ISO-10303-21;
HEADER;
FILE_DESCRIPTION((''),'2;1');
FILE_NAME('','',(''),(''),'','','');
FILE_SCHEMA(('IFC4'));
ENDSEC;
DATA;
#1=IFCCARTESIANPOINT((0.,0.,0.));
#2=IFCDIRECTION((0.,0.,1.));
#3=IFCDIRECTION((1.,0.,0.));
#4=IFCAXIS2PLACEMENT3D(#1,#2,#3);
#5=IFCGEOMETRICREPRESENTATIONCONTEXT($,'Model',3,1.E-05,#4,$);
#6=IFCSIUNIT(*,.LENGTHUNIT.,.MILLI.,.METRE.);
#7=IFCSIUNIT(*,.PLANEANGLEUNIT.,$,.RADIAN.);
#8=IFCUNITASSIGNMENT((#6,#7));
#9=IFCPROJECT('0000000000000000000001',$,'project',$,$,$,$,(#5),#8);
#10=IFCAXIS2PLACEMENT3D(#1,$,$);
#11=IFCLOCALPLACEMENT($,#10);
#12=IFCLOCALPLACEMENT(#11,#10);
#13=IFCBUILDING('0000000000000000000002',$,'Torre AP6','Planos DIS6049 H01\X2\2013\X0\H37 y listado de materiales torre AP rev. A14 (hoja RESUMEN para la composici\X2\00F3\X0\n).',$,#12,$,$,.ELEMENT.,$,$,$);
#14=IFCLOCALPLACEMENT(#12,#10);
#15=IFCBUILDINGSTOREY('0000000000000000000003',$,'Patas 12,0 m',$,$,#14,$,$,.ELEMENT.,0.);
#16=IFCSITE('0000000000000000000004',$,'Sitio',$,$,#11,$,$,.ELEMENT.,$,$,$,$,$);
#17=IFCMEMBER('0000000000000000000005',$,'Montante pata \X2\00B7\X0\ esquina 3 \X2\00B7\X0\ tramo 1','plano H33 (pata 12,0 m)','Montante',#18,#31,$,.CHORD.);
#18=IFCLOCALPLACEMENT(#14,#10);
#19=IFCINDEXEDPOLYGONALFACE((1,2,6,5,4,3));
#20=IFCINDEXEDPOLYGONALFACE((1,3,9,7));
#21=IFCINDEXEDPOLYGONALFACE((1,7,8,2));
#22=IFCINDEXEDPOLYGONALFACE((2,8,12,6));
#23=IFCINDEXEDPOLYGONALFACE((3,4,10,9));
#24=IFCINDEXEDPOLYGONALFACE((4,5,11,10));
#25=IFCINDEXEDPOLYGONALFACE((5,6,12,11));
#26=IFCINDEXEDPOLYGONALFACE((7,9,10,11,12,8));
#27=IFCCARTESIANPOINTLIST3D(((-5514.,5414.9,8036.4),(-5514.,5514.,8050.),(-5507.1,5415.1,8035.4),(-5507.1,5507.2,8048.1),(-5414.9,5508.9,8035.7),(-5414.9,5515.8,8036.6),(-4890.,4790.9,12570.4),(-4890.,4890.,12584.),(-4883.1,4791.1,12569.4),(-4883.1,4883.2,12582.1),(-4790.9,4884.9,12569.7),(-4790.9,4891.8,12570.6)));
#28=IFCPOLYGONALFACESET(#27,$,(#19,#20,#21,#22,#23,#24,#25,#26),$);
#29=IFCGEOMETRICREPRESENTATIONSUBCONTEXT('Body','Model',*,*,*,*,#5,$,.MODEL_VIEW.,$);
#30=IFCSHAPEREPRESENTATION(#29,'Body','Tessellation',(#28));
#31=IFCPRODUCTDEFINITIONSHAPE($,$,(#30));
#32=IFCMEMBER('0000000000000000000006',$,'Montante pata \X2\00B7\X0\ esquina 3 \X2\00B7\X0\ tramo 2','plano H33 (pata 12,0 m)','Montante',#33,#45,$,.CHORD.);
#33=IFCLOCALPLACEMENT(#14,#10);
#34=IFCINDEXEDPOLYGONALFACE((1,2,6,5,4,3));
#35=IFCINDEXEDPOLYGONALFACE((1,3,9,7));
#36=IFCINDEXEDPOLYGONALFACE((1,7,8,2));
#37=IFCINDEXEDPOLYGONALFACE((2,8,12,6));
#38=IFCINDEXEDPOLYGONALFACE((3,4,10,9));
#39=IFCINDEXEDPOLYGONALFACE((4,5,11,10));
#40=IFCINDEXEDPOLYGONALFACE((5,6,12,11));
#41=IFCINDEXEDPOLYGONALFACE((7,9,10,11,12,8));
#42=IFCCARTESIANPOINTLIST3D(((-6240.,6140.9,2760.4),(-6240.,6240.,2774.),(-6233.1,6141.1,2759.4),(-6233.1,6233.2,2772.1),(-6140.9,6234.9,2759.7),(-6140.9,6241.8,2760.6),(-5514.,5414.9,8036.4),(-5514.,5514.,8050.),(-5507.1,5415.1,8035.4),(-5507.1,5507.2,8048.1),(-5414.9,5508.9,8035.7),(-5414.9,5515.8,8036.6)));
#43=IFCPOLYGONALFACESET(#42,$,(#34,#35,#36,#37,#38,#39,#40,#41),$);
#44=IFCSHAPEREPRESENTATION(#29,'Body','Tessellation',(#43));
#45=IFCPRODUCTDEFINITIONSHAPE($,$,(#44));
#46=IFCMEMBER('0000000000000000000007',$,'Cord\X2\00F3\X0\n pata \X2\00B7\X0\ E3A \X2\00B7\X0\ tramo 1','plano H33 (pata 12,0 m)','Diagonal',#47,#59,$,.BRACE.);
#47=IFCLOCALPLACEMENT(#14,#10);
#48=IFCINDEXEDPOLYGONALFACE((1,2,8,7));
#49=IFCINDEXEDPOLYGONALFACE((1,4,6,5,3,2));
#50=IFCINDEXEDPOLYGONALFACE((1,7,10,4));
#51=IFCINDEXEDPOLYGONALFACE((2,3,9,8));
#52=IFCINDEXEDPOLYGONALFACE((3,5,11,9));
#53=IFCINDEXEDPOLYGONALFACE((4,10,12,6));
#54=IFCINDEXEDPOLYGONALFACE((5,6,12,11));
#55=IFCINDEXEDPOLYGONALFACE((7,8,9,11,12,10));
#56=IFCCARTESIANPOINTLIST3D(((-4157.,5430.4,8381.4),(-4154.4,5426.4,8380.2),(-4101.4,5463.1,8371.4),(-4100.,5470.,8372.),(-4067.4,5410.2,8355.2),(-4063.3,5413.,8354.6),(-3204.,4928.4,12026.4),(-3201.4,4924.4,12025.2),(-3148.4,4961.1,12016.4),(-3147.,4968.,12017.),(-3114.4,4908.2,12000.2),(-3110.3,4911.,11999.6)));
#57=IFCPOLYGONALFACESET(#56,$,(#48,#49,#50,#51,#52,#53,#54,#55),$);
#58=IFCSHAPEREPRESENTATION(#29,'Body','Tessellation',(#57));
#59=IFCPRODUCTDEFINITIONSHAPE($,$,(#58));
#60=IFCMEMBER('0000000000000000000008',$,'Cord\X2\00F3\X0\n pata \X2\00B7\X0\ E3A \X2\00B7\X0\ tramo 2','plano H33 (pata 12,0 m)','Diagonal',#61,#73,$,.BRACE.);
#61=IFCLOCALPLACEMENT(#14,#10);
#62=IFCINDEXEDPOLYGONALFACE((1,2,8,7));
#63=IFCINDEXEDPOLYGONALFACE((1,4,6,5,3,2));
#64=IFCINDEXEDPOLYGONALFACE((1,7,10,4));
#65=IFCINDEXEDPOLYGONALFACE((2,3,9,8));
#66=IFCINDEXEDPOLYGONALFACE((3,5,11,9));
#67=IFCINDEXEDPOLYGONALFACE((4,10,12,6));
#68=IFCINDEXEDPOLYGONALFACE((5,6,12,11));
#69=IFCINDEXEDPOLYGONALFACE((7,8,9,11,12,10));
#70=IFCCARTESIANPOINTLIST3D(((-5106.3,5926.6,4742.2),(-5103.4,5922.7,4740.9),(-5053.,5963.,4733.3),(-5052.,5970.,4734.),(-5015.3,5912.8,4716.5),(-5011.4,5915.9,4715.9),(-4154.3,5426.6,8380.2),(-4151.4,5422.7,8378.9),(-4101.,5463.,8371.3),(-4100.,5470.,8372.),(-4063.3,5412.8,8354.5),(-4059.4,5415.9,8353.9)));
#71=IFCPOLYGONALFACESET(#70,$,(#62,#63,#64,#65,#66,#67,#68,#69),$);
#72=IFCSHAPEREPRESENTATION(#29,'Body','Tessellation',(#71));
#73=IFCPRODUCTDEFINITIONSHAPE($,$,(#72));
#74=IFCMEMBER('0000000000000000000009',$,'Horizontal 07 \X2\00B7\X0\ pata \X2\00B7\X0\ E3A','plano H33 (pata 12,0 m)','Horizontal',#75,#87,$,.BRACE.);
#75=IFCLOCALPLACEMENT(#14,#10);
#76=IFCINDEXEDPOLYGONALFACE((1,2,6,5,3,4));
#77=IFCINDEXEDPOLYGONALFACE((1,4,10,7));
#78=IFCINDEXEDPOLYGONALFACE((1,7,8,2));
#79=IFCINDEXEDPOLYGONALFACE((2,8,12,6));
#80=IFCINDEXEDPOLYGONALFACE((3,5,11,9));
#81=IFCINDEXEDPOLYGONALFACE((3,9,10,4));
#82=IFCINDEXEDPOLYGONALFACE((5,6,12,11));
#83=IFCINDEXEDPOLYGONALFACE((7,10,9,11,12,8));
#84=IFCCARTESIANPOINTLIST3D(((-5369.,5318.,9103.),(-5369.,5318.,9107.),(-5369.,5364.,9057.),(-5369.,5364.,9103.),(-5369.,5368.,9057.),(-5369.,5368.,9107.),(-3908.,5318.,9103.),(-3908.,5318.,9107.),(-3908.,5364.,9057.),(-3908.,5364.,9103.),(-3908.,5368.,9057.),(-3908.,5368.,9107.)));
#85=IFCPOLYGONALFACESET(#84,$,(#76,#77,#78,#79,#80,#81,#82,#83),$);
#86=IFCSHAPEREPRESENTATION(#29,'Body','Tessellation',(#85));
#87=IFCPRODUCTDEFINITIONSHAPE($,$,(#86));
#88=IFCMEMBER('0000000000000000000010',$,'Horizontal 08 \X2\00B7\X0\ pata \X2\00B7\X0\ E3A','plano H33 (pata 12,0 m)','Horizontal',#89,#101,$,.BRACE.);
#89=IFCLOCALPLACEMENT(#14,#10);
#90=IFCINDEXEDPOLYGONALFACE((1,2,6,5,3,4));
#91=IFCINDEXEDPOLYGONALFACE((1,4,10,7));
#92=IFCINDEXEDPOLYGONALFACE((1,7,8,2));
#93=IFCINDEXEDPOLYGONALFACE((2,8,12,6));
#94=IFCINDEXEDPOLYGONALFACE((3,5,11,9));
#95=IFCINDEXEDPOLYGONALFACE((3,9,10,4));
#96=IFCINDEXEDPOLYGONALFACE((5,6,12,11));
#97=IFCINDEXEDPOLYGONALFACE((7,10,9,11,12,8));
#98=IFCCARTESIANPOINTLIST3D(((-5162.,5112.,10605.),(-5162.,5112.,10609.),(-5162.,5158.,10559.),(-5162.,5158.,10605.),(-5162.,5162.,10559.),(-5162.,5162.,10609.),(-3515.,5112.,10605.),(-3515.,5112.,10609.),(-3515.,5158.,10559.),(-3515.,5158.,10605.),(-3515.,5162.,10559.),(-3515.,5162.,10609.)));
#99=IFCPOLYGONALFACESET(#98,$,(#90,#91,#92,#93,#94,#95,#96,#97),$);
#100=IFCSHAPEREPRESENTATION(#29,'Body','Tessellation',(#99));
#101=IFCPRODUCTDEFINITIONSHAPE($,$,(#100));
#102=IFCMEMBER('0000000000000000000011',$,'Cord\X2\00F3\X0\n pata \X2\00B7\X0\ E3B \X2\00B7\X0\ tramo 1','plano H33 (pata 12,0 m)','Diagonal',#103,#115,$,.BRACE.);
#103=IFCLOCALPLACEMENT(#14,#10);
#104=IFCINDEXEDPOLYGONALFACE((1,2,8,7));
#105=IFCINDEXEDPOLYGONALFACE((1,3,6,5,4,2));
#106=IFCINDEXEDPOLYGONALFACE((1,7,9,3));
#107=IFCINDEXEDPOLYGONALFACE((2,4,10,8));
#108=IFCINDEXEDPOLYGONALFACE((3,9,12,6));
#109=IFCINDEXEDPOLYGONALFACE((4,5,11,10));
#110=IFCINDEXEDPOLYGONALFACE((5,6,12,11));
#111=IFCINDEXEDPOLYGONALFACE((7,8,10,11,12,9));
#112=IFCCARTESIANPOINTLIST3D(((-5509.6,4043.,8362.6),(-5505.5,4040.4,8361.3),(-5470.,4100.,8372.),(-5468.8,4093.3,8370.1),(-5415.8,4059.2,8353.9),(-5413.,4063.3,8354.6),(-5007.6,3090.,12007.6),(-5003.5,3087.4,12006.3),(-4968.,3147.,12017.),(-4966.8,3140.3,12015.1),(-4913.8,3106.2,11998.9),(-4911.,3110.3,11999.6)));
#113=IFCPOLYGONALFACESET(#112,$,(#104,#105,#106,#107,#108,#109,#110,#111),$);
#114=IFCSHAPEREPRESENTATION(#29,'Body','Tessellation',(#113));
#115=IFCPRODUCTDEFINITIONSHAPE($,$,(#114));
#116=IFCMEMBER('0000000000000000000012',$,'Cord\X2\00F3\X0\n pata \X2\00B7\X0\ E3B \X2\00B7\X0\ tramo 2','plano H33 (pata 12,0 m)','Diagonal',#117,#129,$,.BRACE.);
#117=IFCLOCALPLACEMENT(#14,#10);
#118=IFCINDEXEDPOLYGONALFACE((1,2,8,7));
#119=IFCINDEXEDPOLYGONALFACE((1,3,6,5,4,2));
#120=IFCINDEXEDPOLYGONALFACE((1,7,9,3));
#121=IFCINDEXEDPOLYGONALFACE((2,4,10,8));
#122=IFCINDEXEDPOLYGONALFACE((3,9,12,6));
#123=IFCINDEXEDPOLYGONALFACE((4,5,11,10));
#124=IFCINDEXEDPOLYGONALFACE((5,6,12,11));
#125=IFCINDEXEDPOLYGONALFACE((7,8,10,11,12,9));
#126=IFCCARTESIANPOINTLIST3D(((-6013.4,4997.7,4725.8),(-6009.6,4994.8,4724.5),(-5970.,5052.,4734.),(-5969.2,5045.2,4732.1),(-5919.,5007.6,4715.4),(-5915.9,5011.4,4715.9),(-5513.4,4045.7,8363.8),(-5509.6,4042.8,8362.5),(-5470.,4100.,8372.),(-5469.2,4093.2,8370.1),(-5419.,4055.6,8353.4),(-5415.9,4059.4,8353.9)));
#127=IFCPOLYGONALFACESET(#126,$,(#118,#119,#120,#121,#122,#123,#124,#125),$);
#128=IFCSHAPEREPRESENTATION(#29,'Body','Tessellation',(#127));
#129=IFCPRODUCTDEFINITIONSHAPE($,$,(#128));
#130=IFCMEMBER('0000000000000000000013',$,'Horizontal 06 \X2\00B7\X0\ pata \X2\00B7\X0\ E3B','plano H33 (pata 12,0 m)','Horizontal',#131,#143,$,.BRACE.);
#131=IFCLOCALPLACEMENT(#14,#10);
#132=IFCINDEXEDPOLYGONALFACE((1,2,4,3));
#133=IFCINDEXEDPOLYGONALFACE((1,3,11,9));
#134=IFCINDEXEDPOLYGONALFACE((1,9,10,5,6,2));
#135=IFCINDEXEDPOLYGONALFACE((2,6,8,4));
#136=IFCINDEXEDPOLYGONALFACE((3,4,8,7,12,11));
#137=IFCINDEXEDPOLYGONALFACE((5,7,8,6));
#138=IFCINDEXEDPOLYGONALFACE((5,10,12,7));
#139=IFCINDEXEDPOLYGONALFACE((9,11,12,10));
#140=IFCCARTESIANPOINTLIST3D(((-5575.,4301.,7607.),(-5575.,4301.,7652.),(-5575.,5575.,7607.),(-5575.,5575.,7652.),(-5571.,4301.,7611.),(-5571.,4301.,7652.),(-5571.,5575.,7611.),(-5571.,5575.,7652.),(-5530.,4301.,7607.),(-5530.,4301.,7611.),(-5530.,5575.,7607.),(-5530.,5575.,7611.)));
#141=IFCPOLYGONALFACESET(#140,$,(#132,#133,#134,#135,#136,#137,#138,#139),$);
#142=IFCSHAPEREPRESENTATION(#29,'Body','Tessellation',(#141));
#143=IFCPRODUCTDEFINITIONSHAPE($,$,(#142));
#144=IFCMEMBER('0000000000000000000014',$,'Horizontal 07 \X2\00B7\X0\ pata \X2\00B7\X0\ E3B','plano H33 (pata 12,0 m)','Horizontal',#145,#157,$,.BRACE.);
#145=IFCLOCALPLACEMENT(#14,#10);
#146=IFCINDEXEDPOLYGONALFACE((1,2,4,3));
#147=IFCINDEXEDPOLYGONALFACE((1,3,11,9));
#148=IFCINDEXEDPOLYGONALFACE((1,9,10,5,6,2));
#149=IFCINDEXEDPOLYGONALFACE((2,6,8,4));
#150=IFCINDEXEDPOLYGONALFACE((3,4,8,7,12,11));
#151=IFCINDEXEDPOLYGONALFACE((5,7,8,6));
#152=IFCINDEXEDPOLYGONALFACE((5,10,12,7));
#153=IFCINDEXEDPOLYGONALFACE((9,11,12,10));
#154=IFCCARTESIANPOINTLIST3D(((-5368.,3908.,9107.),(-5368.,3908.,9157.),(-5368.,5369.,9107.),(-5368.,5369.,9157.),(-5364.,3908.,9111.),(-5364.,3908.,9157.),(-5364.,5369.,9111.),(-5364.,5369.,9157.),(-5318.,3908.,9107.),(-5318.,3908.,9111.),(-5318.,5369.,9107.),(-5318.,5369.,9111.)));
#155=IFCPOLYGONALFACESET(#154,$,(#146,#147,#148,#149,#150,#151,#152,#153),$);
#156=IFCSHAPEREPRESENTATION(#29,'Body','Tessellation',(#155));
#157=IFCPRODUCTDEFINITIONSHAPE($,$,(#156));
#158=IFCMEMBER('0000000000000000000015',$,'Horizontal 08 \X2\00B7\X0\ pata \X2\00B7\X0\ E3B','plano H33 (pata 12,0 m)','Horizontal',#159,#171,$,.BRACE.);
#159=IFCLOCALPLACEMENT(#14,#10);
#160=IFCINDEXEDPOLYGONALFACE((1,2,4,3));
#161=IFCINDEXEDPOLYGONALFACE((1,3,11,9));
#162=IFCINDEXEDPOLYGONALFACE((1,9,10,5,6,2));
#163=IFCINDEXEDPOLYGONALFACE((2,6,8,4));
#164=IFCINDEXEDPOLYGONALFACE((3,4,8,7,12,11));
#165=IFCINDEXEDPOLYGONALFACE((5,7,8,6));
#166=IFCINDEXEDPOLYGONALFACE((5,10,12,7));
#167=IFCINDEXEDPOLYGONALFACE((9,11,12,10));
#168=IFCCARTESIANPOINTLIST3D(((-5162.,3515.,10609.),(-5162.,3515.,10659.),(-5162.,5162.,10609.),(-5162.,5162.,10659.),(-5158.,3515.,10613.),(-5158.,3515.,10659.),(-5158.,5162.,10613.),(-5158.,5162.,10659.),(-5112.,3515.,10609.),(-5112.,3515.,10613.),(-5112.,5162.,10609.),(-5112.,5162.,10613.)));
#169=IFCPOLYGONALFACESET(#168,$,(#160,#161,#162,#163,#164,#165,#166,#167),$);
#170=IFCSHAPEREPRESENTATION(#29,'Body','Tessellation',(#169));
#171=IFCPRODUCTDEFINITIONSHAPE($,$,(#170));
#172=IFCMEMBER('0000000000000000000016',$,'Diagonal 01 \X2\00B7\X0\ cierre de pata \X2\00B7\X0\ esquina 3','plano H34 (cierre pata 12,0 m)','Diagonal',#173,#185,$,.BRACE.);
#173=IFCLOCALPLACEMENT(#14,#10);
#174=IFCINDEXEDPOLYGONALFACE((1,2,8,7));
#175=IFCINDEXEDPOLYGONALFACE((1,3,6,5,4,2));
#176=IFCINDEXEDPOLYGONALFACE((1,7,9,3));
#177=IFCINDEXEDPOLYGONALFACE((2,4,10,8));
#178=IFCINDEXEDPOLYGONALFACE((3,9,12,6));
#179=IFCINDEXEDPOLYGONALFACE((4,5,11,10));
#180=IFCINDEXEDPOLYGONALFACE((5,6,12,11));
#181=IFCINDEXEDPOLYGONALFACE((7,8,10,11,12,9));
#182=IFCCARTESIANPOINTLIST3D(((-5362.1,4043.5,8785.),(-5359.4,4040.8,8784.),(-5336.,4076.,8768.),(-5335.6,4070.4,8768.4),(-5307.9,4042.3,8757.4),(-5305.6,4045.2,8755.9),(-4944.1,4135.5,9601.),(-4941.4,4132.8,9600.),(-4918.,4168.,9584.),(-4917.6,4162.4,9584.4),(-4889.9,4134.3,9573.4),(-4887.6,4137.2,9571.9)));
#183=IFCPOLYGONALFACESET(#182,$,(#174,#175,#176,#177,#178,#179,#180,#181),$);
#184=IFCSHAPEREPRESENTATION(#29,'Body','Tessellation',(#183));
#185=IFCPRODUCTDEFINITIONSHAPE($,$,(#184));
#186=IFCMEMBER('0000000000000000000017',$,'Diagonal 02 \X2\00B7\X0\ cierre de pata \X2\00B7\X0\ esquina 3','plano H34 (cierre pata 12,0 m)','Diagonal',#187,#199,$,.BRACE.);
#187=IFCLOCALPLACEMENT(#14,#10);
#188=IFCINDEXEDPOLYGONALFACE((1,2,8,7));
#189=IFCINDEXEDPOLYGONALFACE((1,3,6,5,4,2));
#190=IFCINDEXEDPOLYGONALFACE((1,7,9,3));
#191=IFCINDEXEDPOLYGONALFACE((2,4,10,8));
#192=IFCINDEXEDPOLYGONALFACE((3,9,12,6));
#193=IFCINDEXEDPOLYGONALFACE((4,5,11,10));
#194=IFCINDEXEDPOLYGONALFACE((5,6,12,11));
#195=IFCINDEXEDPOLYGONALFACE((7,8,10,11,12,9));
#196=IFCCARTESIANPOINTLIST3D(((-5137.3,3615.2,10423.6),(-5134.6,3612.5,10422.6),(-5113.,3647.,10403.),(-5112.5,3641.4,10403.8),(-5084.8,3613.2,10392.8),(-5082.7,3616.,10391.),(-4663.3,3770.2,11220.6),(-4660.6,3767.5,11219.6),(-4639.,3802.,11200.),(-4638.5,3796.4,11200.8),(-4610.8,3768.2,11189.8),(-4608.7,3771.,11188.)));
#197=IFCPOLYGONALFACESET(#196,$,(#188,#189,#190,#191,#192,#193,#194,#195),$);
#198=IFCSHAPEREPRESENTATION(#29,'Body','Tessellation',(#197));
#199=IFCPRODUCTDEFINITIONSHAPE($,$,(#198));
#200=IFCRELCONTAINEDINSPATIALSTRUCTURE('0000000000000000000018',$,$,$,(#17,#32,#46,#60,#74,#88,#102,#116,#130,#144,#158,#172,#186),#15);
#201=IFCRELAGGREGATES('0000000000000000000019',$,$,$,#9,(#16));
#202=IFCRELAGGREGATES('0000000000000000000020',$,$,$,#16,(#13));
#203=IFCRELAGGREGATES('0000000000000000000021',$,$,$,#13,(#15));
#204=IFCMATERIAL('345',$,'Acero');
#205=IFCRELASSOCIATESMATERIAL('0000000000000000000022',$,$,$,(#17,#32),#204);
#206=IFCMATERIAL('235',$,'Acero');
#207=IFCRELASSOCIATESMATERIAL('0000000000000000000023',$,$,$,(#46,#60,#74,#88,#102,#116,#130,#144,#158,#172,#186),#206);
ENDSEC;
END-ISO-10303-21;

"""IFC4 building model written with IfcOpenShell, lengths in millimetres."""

from ifc_helpers import new_model, si_unit, frame, frame_2d, origin, origin_with_axes, place, context, subcontext, project, spatial, l_section, extrude, material, element, save


model = new_model("IFC4")

# Units and contexts
model_context = context("Model", 3, precision=1e-05, world=origin_with_axes())
body_context = subcontext(model_context, "Body", "Model", "MODEL_VIEW")
ifc_project = project(units=[si_unit("LENGTHUNIT", "METRE", prefix="MILLI"), si_unit("PLANEANGLEUNIT", "RADIAN")], contexts=[model_context])

# Site, building, storey
site_placement = place(None, origin())
site = spatial("IfcSite", under=ifc_project, at=site_placement, Name="Sitio", CompositionType="ELEMENT")
building_placement = place(site_placement, origin())
building = spatial("IfcBuilding", under=site, at=building_placement, Name="Torre AP6", Description="Planos DIS6049 H01–H37 y listado de materiales torre AP rev. A14 (hoja RESUMEN para la composición).", CompositionType="ELEMENT")
storey_placement = place(building_placement, origin())
storey = spatial("IfcBuildingStorey", under=building, at=storey_placement, Name="Patas 12,0 m", CompositionType="ELEMENT", Elevation=0.0)

# Members
ifc_material_1 = material(Name="345", Category="Acero")
member_1_placement = place(storey_placement, frame((-4890.0, 4890.0, 12584.0), z_axis=(-0.135092, 0.135092, -0.981581), x_axis=(0.990833, 0.018419, -0.13383)))
element("IfcMember", 1, at=member_1_placement, inside=storey, material=ifc_material_1, Name="Montante pata · esquina 3 · tramo 1", Description="plano H33 (pata 12,0 m)", ObjectType="Montante", PredefinedType="CHORD", context=body_context, shape_type="SweptSolid", body=[
    extrude(l_section(Depth=100.0, Width=100.0, Thickness=7.0, at=frame_2d((50.0, 50.0))), None, (0.0, 0.0, 1.0), 4619.1),
])
member_2_placement = place(storey_placement, frame((-5514.0, 5514.0, 8050.0), z_axis=(-0.13507, 0.13507, -0.981586), x_axis=(0.990836, 0.018413, -0.13381)))
element("IfcMember", 2, at=member_2_placement, inside=storey, material=ifc_material_1, Name="Montante pata · esquina 3 · tramo 2", Description="plano H33 (pata 12,0 m)", ObjectType="Montante", PredefinedType="CHORD", context=body_context, shape_type="SweptSolid", body=[
    extrude(l_section(Depth=100.0, Width=100.0, Thickness=7.0, at=frame_2d((50.0, 50.0))), None, (0.0, 0.0, 1.0), 5375.0),
])
ifc_material_2 = material(Name="235", Category="Acero")
member_3_placement = place(storey_placement, frame((-3147.0, 4968.0, 12017.0), z_axis=(-0.250735, 0.132077, -0.959003), x_axis=(0.524098, -0.814388, -0.249187)))
element("IfcMember", 3, at=member_3_placement, inside=storey, material=ifc_material_2, Name="Cordón pata · E3A · tramo 1", Description="plano H33 (pata 12,0 m)", ObjectType="Diagonal", PredefinedType="BRACE", context=body_context, shape_type="SweptSolid", body=[
    extrude(l_section(Depth=70.0, Width=70.0, Thickness=5.0, at=frame_2d((35.0, 35.0))), None, (0.0, 0.0, 1.0), 3800.8),
])
member_4_placement = place(storey_placement, frame((-4100.0, 5470.0, 8372.0), z_axis=(-0.250949, 0.131801, -0.958985), x_axis=(0.579405, -0.773167, -0.257883)))
element("IfcMember", 4, at=member_4_placement, inside=storey, material=ifc_material_2, Name="Cordón pata · E3A · tramo 2", Description="plano H33 (pata 12,0 m)", ObjectType="Diagonal", PredefinedType="BRACE", context=body_context, shape_type="SweptSolid", body=[
    extrude(l_section(Depth=70.0, Width=70.0, Thickness=5.0, at=frame_2d((35.0, 35.0))), None, (0.0, 0.0, 1.0), 3793.6),
])
member_5_placement = place(storey_placement, frame((-5369.0, 5368.0, 9107.0), z_axis=(1.0, 0.0, 0.0), x_axis=(0.0, -1.0, 0.0)))
element("IfcMember", 5, at=member_5_placement, inside=storey, material=ifc_material_2, Name="Horizontal 07 · pata · E3A", Description="plano H33 (pata 12,0 m)", ObjectType="Horizontal", PredefinedType="BRACE", context=body_context, shape_type="SweptSolid", body=[
    extrude(l_section(Depth=50.0, Width=50.0, Thickness=4.0, at=frame_2d((25.0, 25.0))), None, (0.0, 0.0, 1.0), 1461.0),
])
member_6_placement = place(storey_placement, frame((-5162.0, 5162.0, 10609.0), z_axis=(1.0, 0.0, 0.0), x_axis=(0.0, -1.0, 0.0)))
element("IfcMember", 6, at=member_6_placement, inside=storey, material=ifc_material_2, Name="Horizontal 08 · pata · E3A", Description="plano H33 (pata 12,0 m)", ObjectType="Horizontal", PredefinedType="BRACE", context=body_context, shape_type="SweptSolid", body=[
    extrude(l_section(Depth=50.0, Width=50.0, Thickness=4.0, at=frame_2d((25.0, 25.0))), None, (0.0, 0.0, 1.0), 1647.0),
])
member_7_placement = place(storey_placement, frame((-4968.0, 3147.0, 12017.0), z_axis=(-0.132077, 0.250735, -0.959003), x_axis=(0.814388, -0.524098, -0.249187)))
element("IfcMember", 7, at=member_7_placement, inside=storey, material=ifc_material_2, Name="Cordón pata · E3B · tramo 1", Description="plano H33 (pata 12,0 m)", ObjectType="Diagonal", PredefinedType="BRACE", context=body_context, shape_type="SweptSolid", body=[
    extrude(l_section(Depth=70.0, Width=70.0, Thickness=5.0, at=frame_2d((35.0, 35.0))), None, (0.0, 0.0, 1.0), 3800.8),
])
member_8_placement = place(storey_placement, frame((-5470.0, 4100.0, 8372.0), z_axis=(-0.131801, 0.250949, -0.958985), x_axis=(0.773167, -0.579405, -0.257883)))
element("IfcMember", 8, at=member_8_placement, inside=storey, material=ifc_material_2, Name="Cordón pata · E3B · tramo 2", Description="plano H33 (pata 12,0 m)", ObjectType="Diagonal", PredefinedType="BRACE", context=body_context, shape_type="SweptSolid", body=[
    extrude(l_section(Depth=70.0, Width=70.0, Thickness=5.0, at=frame_2d((35.0, 35.0))), None, (0.0, 0.0, 1.0), 3793.6),
])
member_9_placement = place(storey_placement, frame((-5575.0, 5575.0, 7607.0), z_axis=(0.0, -1.0, 0.0), x_axis=(1.0, 0.0, 0.0)))
element("IfcMember", 9, at=member_9_placement, inside=storey, material=ifc_material_2, Name="Horizontal 06 · pata · E3B", Description="plano H33 (pata 12,0 m)", ObjectType="Horizontal", PredefinedType="BRACE", context=body_context, shape_type="SweptSolid", body=[
    extrude(l_section(Depth=45.0, Width=45.0, Thickness=4.0, at=frame_2d((22.5, 22.5))), None, (0.0, 0.0, 1.0), 1274.0),
])
member_10_placement = place(storey_placement, frame((-5368.0, 5369.0, 9107.0), z_axis=(0.0, -1.0, 0.0), x_axis=(1.0, 0.0, 0.0)))
element("IfcMember", 10, at=member_10_placement, inside=storey, material=ifc_material_2, Name="Horizontal 07 · pata · E3B", Description="plano H33 (pata 12,0 m)", ObjectType="Horizontal", PredefinedType="BRACE", context=body_context, shape_type="SweptSolid", body=[
    extrude(l_section(Depth=50.0, Width=50.0, Thickness=4.0, at=frame_2d((25.0, 25.0))), None, (0.0, 0.0, 1.0), 1461.0),
])
member_11_placement = place(storey_placement, frame((-5162.0, 5162.0, 10609.0), z_axis=(0.0, -1.0, 0.0), x_axis=(1.0, 0.0, 0.0)))
element("IfcMember", 11, at=member_11_placement, inside=storey, material=ifc_material_2, Name="Horizontal 08 · pata · E3B", Description="plano H33 (pata 12,0 m)", ObjectType="Horizontal", PredefinedType="BRACE", context=body_context, shape_type="SweptSolid", body=[
    extrude(l_section(Depth=50.0, Width=50.0, Thickness=4.0, at=frame_2d((25.0, 25.0))), None, (0.0, 0.0, 1.0), 1647.0),
])
member_12_placement = place(storey_placement, frame((-4918.0, 4168.0, 9584.0), z_axis=(-0.45364, -0.099844, -0.885574), x_axis=(0.676631, -0.685291, -0.269344)))
element("IfcMember", 12, at=member_12_placement, inside=storey, material=ifc_material_2, Name="Diagonal 01 · cierre de pata · esquina 3", Description="plano H34 (cierre pata 12,0 m)", ObjectType="Diagonal", PredefinedType="BRACE", context=body_context, shape_type="SweptSolid", body=[
    extrude(l_section(Depth=45.0, Width=45.0, Thickness=4.0, at=frame_2d((22.5, 22.5))), None, (0.0, 0.0, 1.0), 921.4),
])
member_13_placement = place(storey_placement, frame((-4639.0, 3802.0, 11200.0), z_axis=(-0.504167, -0.164865, -0.847724), x_axis=(0.674329, -0.688407, -0.267163)))
element("IfcMember", 13, at=member_13_placement, inside=storey, material=ifc_material_2, Name="Diagonal 02 · cierre de pata · esquina 3", Description="plano H34 (cierre pata 12,0 m)", ObjectType="Diagonal", PredefinedType="BRACE", context=body_context, shape_type="SweptSolid", body=[
    extrude(l_section(Depth=45.0, Width=45.0, Thickness=4.0, at=frame_2d((22.5, 22.5))), None, (0.0, 0.0, 1.0), 940.2),
])

save(model, "model.ifc")
